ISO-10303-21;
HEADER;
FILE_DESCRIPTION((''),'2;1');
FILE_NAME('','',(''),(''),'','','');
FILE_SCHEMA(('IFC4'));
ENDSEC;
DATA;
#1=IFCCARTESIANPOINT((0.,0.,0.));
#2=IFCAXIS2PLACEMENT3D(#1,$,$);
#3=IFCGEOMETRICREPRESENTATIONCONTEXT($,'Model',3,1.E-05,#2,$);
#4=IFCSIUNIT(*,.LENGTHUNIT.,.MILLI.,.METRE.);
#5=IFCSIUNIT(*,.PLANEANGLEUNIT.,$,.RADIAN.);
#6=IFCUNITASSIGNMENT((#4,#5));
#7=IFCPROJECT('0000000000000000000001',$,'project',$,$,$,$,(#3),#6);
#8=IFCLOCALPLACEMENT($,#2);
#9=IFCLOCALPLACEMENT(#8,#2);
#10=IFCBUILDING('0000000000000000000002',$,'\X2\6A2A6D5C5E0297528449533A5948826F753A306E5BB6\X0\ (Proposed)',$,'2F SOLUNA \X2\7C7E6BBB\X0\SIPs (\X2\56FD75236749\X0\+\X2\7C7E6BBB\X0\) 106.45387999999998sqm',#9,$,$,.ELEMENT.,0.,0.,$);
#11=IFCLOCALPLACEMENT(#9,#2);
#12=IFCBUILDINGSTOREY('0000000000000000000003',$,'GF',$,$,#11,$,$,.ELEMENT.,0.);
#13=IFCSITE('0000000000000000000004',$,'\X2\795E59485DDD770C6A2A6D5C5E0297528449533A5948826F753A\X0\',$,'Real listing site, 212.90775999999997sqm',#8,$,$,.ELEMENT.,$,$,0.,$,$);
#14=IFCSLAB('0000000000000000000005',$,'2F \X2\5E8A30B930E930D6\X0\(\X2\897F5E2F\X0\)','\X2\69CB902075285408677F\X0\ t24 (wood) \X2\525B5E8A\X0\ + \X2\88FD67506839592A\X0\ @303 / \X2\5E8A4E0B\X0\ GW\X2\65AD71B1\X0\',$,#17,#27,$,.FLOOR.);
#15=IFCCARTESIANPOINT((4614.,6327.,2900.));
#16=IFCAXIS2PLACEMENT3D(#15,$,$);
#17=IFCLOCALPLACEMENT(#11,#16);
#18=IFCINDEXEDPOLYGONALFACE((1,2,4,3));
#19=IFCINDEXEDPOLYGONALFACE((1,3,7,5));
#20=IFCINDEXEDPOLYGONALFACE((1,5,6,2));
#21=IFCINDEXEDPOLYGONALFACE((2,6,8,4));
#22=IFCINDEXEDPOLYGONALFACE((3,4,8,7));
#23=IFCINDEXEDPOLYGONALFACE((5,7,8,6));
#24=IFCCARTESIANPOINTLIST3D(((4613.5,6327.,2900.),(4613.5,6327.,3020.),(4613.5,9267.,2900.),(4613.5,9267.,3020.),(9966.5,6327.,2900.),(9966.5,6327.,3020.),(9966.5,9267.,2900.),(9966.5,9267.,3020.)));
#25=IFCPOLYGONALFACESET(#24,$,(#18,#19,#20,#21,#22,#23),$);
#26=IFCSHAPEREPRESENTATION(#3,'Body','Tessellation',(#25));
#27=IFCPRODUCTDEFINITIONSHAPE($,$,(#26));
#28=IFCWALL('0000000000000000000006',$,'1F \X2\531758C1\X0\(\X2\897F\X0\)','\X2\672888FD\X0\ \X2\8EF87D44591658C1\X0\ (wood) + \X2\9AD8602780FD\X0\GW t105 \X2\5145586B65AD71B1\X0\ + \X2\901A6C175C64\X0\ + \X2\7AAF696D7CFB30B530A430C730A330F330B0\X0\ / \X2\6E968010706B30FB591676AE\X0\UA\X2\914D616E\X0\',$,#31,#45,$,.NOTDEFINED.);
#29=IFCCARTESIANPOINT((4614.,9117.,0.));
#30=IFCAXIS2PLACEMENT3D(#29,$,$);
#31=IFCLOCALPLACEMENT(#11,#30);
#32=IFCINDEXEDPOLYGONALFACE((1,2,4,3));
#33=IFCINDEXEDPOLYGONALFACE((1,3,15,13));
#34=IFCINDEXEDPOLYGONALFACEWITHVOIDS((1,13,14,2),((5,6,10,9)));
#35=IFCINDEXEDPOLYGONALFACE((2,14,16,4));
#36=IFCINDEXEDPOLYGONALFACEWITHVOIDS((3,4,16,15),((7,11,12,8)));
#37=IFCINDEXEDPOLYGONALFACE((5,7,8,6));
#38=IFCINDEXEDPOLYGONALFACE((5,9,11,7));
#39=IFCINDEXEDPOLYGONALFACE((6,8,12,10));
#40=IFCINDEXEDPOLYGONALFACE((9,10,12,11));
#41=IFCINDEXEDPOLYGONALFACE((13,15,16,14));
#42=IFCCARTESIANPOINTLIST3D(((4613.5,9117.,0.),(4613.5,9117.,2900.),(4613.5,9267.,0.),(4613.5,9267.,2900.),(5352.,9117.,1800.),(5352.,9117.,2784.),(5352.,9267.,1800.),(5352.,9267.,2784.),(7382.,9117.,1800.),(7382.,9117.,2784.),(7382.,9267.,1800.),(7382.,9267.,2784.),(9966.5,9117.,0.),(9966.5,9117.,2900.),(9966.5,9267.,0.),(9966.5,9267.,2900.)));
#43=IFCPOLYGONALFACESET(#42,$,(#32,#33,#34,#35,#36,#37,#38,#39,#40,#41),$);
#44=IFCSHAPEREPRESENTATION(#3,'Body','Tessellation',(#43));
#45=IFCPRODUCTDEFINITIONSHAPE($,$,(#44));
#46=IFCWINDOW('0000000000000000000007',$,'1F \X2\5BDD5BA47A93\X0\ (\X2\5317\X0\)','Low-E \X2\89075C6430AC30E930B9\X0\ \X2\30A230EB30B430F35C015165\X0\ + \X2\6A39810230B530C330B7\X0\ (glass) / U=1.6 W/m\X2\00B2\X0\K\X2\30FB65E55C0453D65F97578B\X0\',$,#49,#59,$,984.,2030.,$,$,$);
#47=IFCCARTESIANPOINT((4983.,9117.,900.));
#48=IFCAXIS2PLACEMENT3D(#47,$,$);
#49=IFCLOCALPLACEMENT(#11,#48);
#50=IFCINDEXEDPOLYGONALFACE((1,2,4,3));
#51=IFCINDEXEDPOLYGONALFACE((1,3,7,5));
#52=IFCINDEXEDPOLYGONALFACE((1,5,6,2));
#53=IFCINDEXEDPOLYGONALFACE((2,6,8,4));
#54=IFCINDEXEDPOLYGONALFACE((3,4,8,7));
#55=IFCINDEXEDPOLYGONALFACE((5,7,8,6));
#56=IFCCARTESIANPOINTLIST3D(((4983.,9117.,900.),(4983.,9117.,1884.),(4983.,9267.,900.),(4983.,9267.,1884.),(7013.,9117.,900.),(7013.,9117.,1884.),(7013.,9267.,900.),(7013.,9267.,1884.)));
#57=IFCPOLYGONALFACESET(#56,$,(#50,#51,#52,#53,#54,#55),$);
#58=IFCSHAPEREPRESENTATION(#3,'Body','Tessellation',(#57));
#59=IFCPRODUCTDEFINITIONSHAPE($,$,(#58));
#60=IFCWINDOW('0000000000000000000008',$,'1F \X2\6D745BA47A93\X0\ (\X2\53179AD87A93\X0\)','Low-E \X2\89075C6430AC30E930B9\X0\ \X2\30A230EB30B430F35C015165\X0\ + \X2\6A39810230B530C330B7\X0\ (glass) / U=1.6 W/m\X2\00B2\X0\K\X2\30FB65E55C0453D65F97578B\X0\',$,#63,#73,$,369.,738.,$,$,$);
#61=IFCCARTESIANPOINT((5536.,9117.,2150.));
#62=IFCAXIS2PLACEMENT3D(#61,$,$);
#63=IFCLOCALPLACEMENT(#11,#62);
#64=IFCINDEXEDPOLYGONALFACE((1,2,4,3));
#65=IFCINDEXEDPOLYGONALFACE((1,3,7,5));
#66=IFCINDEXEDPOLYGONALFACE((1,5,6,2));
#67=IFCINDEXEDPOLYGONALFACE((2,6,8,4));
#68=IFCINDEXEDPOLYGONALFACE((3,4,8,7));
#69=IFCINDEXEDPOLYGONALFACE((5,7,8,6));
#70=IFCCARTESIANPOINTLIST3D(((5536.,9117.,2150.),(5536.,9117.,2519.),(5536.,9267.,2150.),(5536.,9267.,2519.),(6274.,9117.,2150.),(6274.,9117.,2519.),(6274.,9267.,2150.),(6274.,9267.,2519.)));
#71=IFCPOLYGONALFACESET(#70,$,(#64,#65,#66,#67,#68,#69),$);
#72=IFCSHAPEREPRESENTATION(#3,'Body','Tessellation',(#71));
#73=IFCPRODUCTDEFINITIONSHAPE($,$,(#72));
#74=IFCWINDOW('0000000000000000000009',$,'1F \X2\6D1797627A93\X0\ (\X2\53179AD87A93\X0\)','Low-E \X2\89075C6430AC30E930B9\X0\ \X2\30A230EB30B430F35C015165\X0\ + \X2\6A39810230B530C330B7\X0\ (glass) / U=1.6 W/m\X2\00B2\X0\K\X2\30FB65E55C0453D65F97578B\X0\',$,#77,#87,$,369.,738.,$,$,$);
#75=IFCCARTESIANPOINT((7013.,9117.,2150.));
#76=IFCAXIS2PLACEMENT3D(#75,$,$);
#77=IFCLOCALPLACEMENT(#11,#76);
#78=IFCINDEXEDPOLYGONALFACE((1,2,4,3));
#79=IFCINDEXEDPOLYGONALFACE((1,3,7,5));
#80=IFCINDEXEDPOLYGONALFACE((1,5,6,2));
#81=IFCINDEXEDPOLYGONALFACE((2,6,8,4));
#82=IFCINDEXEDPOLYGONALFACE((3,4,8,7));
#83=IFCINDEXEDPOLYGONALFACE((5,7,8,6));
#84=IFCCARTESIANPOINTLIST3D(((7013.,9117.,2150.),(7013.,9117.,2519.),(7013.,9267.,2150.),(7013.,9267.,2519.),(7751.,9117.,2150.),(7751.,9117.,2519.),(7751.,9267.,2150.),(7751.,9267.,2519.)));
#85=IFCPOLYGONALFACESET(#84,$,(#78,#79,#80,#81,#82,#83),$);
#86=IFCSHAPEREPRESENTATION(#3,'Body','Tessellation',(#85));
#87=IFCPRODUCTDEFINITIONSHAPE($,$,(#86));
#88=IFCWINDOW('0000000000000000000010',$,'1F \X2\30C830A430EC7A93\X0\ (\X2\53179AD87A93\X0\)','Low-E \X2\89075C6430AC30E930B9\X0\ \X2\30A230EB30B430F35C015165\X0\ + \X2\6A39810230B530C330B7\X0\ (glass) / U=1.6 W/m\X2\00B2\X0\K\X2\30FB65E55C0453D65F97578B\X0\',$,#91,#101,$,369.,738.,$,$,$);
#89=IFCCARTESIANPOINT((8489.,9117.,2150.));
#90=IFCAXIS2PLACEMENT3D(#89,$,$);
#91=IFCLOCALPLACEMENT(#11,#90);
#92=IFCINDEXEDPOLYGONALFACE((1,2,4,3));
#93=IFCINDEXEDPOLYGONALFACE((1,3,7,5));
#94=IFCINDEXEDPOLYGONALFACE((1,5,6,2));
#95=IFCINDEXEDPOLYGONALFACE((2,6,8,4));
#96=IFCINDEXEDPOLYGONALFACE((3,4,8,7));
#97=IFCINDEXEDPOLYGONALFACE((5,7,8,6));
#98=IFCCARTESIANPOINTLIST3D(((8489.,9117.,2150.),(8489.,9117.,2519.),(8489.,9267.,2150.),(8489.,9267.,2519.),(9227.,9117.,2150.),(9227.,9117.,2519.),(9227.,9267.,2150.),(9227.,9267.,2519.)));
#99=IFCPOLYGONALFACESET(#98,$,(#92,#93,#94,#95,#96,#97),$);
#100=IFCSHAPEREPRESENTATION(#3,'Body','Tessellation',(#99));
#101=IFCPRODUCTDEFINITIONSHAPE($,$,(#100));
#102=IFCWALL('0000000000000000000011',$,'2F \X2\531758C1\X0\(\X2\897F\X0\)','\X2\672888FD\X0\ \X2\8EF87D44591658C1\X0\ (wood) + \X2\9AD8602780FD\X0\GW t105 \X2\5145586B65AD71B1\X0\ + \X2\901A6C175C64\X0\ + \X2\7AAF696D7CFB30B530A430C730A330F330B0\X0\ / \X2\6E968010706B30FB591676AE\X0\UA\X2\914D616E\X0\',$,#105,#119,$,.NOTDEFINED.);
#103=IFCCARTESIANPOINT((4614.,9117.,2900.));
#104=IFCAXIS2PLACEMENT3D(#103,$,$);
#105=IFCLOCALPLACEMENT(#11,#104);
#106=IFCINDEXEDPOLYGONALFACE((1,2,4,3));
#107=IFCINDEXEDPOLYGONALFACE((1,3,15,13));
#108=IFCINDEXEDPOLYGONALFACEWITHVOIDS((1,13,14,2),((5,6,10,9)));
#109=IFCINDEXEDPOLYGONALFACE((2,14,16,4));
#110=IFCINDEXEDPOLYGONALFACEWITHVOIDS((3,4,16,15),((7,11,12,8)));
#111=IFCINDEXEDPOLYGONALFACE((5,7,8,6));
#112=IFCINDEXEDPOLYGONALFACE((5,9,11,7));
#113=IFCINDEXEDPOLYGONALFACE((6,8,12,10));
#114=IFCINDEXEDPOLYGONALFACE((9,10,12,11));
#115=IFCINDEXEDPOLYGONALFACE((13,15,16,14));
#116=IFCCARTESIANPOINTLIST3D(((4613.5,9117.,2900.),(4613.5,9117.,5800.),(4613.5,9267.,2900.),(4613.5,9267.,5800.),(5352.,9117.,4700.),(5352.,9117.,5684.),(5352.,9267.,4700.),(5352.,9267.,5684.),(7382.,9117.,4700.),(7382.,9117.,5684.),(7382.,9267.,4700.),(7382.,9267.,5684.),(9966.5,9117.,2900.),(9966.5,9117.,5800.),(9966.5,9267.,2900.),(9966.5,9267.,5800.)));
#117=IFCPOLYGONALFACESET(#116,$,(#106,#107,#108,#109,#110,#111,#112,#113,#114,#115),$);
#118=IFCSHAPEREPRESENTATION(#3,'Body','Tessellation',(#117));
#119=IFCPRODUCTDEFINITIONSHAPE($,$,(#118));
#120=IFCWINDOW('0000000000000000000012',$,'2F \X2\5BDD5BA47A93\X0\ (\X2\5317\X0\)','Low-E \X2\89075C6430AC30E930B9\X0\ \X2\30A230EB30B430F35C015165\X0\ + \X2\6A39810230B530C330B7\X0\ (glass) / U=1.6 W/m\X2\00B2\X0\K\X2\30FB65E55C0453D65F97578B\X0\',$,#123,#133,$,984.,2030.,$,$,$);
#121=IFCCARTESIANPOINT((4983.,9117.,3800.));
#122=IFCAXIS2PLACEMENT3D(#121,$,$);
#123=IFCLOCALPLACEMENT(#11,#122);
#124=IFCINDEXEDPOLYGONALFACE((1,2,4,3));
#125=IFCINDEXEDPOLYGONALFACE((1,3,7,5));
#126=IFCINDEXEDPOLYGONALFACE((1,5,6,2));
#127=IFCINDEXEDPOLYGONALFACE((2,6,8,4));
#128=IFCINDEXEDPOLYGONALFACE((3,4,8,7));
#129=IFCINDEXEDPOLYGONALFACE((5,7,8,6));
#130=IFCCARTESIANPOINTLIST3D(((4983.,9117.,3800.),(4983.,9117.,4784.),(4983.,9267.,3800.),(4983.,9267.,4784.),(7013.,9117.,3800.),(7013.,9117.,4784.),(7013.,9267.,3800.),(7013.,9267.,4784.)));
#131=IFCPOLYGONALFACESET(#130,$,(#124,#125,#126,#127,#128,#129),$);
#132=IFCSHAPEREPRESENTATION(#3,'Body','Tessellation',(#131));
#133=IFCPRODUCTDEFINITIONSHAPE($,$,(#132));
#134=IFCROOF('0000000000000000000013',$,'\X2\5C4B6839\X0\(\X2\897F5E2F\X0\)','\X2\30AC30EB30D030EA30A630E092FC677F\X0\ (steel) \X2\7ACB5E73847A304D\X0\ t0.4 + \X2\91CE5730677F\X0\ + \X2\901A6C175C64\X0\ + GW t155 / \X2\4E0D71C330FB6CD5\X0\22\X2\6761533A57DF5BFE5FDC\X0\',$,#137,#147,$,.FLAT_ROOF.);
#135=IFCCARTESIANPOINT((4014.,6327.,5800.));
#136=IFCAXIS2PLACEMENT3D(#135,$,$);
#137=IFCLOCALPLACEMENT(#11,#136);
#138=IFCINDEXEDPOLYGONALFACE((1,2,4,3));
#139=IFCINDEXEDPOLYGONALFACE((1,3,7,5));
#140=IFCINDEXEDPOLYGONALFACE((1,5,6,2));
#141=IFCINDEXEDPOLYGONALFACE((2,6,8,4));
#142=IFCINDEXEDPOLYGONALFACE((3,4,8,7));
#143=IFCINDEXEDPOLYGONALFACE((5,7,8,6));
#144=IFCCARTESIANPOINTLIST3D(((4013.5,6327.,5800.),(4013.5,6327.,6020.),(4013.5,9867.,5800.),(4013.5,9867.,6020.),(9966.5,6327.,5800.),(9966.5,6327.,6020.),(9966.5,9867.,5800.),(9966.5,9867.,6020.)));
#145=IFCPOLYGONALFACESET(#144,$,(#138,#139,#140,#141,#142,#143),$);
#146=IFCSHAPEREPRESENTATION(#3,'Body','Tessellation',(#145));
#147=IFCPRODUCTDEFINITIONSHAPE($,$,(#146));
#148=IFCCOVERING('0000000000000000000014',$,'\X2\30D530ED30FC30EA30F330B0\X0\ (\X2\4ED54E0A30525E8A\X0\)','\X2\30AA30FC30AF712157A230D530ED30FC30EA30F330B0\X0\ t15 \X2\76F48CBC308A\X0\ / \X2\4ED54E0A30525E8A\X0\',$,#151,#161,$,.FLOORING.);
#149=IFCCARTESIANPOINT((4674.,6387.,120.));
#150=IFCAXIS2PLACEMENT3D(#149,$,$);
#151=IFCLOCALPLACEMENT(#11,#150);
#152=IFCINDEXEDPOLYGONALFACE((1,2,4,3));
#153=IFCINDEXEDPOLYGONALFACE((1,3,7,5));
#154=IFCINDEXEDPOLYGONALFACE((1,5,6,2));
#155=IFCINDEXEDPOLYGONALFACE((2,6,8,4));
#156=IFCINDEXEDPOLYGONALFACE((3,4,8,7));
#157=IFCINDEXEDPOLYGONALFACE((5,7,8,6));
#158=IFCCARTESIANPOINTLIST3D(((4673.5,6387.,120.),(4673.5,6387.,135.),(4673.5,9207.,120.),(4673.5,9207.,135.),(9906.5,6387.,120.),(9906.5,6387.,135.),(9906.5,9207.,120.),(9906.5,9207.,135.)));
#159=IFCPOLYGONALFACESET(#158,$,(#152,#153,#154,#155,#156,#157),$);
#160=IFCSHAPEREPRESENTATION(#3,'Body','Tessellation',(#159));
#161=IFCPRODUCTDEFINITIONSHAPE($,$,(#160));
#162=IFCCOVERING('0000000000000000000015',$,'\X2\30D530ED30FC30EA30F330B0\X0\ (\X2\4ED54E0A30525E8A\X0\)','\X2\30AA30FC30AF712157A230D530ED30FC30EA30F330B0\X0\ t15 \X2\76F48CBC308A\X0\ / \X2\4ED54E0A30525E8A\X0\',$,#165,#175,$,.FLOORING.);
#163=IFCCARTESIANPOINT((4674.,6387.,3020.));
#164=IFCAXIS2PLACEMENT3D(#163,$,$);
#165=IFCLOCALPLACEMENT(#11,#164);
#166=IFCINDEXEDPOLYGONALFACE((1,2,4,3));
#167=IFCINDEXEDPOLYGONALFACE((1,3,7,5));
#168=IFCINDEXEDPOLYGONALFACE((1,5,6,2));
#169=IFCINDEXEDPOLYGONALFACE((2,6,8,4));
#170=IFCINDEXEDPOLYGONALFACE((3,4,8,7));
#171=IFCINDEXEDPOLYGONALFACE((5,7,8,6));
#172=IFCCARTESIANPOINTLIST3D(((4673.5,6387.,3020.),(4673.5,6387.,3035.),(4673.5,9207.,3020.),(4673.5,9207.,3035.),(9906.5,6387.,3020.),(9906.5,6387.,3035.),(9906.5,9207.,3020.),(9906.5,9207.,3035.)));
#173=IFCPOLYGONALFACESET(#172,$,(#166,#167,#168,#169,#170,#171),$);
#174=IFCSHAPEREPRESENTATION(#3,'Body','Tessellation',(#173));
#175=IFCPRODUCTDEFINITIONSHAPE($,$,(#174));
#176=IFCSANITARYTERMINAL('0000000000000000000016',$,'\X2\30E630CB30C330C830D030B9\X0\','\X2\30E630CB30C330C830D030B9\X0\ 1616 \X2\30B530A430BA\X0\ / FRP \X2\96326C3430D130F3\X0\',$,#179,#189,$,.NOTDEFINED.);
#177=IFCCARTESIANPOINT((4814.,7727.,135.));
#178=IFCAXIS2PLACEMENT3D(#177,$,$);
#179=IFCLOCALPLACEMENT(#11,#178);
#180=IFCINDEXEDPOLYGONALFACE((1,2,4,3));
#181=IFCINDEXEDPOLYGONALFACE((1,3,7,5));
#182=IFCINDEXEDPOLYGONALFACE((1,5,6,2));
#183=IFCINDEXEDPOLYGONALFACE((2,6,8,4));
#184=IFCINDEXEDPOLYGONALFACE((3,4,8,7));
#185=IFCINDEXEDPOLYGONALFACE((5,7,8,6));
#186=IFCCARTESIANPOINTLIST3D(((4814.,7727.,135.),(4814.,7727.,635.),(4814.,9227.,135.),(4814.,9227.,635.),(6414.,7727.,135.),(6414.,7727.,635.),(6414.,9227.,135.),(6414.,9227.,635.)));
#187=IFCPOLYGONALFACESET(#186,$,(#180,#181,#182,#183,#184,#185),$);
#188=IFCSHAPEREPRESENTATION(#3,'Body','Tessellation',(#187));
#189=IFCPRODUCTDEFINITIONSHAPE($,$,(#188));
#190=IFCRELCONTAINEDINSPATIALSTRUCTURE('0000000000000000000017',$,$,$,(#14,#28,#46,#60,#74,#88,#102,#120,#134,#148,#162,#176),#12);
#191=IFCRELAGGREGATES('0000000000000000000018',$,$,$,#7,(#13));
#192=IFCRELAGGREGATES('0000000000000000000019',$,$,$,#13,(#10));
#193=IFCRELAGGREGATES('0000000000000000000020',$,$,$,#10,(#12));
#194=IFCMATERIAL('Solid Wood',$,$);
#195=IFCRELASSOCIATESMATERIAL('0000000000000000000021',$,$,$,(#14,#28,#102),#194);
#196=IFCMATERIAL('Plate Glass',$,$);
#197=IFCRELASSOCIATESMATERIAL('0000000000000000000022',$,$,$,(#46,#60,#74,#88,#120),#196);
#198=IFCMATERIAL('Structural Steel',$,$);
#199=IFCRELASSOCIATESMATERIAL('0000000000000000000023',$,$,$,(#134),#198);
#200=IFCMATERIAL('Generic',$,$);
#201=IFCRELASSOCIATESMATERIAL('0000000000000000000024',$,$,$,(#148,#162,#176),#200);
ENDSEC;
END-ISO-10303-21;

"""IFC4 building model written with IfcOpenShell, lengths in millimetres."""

from ifc_helpers import new_model, si_unit, frame, frame_2d, origin, place, context, project, spatial, rectangle, extrude, material, element, fill, save


model = new_model("IFC4")

# Units and contexts
model_context = context("Model", 3, precision=1e-05, world=origin())
ifc_project = project(units=[si_unit("LENGTHUNIT", "METRE", prefix="MILLI"), si_unit("PLANEANGLEUNIT", "RADIAN")], contexts=[model_context])

# Site, building, storey
site_placement = place(None, origin())
site = spatial("IfcSite", under=ifc_project, at=site_placement, Name="神奈川県横浜市青葉区奈良町", ObjectType="Real listing site, 212.90775999999997sqm", CompositionType="ELEMENT", RefElevation=0.0)
building_placement = place(site_placement, origin())
building = spatial("IfcBuilding", under=site, at=building_placement, Name="横浜市青葉区奈良町の家 (Proposed)", ObjectType="2F SOLUNA 籾殻SIPs (国産杉+籾殻) 106.45387999999998sqm", CompositionType="ELEMENT", ElevationOfRefHeight=0.0, ElevationOfTerrain=0.0)
storey_placement = place(building_placement, origin())
storey = spatial("IfcBuildingStorey", under=building, at=storey_placement, Name="GF", CompositionType="ELEMENT", Elevation=0.0)

# Slab
ifc_material_1 = material(Name="Solid Wood")
slab_1_placement = place(storey_placement, frame((4614.0, 6327.0, 2900.0)))
element("IfcSlab", 1, at=slab_1_placement, inside=storey, material=ifc_material_1, Name="2F 床スラブ(西帯)", Description="構造用合板 t24 (wood) 剛床 + 製材根太 @303 / 床下 GW断熱", PredefinedType="FLOOR", context=model_context, shape_type="SweptSolid", body=[
    extrude(rectangle(XDim=5353.0, YDim=2940.0, at=frame_2d((2676.0, 1470.0))), frame((4614.0, 6327.0, 2900.0)), (0.0, 0.0, 1.0), 120.0),
])

# Wall, openings, windows
wall_1_placement = place(storey_placement, frame((4614.0, 9117.0, 0.0)))
wall_1 = element("IfcWall", 2, at=wall_1_placement, inside=storey, material=ifc_material_1, Name="1F 北壁(西)", Description="木製 軸組外壁 (wood) + 高性能GW t105 充填断熱 + 通気層 + 窯業系サイディング / 準耐火・外皮UA配慮", PredefinedType="NOTDEFINED", context=model_context, shape_type="SweptSolid", body=[
    extrude(rectangle(XDim=5353.0, YDim=150.0, at=frame_2d((2676.0, 75.0))), frame((4614.0, 9117.0, 0.0)), (0.0, 0.0, 1.0), 2900.0),
])
opening_1_placement = place(storey_placement, frame((4983.0, 9117.0, 900.0)))
opening_1 = element("IfcOpeningElement", 3, at=opening_1_placement, cuts=wall_1, PredefinedType="NOTDEFINED", context=model_context, shape_type="SweptSolid", body=[
    extrude(rectangle(XDim=2030.0, YDim=150.0, at=frame_2d((1015.0, 75.0))), frame((4983.0, 9117.0, 900.0)), (0.0, 0.0, 1.0), 984.0),
])
opening_2_placement = place(storey_placement, frame((5536.0, 9117.0, 2150.0)))
opening_2 = element("IfcOpeningElement", 4, at=opening_2_placement, cuts=wall_1, PredefinedType="NOTDEFINED", context=model_context, shape_type="SweptSolid", body=[
    extrude(rectangle(XDim=738.0, YDim=150.0, at=frame_2d((369.0, 75.0))), frame((5536.0, 9117.0, 2150.0)), (0.0, 0.0, 1.0), 369.0),
])
opening_3_placement = place(storey_placement, frame((7013.0, 9117.0, 2150.0)))
opening_3 = element("IfcOpeningElement", 5, at=opening_3_placement, cuts=wall_1, PredefinedType="NOTDEFINED", context=model_context, shape_type="SweptSolid", body=[
    extrude(rectangle(XDim=738.0, YDim=150.0, at=frame_2d((369.0, 75.0))), frame((7013.0, 9117.0, 2150.0)), (0.0, 0.0, 1.0), 369.0),
])
opening_4_placement = place(storey_placement, frame((8489.0, 9117.0, 2150.0)))
opening_4 = element("IfcOpeningElement", 6, at=opening_4_placement, cuts=wall_1, PredefinedType="NOTDEFINED", context=model_context, shape_type="SweptSolid", body=[
    extrude(rectangle(XDim=738.0, YDim=150.0, at=frame_2d((369.0, 75.0))), frame((8489.0, 9117.0, 2150.0)), (0.0, 0.0, 1.0), 369.0),
])
ifc_material_2 = material(Name="Plate Glass")
window_1_placement = place(storey_placement, frame((4983.0, 9117.0, 900.0)))
window_1 = element("IfcWindow", 7, at=window_1_placement, inside=storey, material=ifc_material_2, Name="1F 寝室窓 (北)", Description="Low-E 複層ガラス アルゴン封入 + 樹脂サッシ (glass) / U=1.6 W/m²K・日射取得型", OverallHeight=984.0, OverallWidth=2030.0, context=model_context, shape_type="SweptSolid", body=[
    extrude(rectangle(XDim=2030.0, YDim=150.0, at=frame_2d((1015.0, 75.0))), frame((4983.0, 9117.0, 900.0)), (0.0, 0.0, 1.0), 984.0),
])
fill(opening_1, window_1)
window_2_placement = place(storey_placement, frame((5536.0, 9117.0, 2150.0)))
window_2 = element("IfcWindow", 8, at=window_2_placement, inside=storey, material=ifc_material_2, Name="1F 浴室窓 (北高窓)", Description="Low-E 複層ガラス アルゴン封入 + 樹脂サッシ (glass) / U=1.6 W/m²K・日射取得型", OverallHeight=369.0, OverallWidth=738.0, context=model_context, shape_type="SweptSolid", body=[
    extrude(rectangle(XDim=738.0, YDim=150.0, at=frame_2d((369.0, 75.0))), frame((5536.0, 9117.0, 2150.0)), (0.0, 0.0, 1.0), 369.0),
])
fill(opening_2, window_2)
window_3_placement = place(storey_placement, frame((7013.0, 9117.0, 2150.0)))
window_3 = element("IfcWindow", 9, at=window_3_placement, inside=storey, material=ifc_material_2, Name="1F 洗面窓 (北高窓)", Description="Low-E 複層ガラス アルゴン封入 + 樹脂サッシ (glass) / U=1.6 W/m²K・日射取得型", OverallHeight=369.0, OverallWidth=738.0, context=model_context, shape_type="SweptSolid", body=[
    extrude(rectangle(XDim=738.0, YDim=150.0, at=frame_2d((369.0, 75.0))), frame((7013.0, 9117.0, 2150.0)), (0.0, 0.0, 1.0), 369.0),
])
fill(opening_3, window_3)
window_4_placement = place(storey_placement, frame((8489.0, 9117.0, 2150.0)))
window_4 = element("IfcWindow", 10, at=window_4_placement, inside=storey, material=ifc_material_2, Name="1F トイレ窓 (北高窓)", Description="Low-E 複層ガラス アルゴン封入 + 樹脂サッシ (glass) / U=1.6 W/m²K・日射取得型", OverallHeight=369.0, OverallWidth=738.0, context=model_context, shape_type="SweptSolid", body=[
    extrude(rectangle(XDim=738.0, YDim=150.0, at=frame_2d((369.0, 75.0))), frame((8489.0, 9117.0, 2150.0)), (0.0, 0.0, 1.0), 369.0),
])
fill(opening_4, window_4)

# Wall, opening, window
wall_2_placement = place(storey_placement, frame((4614.0, 9117.0, 2900.0)))
wall_2 = element("IfcWall", 11, at=wall_2_placement, inside=storey, material=ifc_material_1, Name="2F 北壁(西)", Description="木製 軸組外壁 (wood) + 高性能GW t105 充填断熱 + 通気層 + 窯業系サイディング / 準耐火・外皮UA配慮", PredefinedType="NOTDEFINED", context=model_context, shape_type="SweptSolid", body=[
    extrude(rectangle(XDim=5353.0, YDim=150.0, at=frame_2d((2676.0, 75.0))), frame((4614.0, 9117.0, 2900.0)), (0.0, 0.0, 1.0), 2900.0),
])
opening_5_placement = place(storey_placement, frame((4983.0, 9117.0, 3800.0)))
opening_5 = element("IfcOpeningElement", 12, at=opening_5_placement, cuts=wall_2, PredefinedType="NOTDEFINED", context=model_context, shape_type="SweptSolid", body=[
    extrude(rectangle(XDim=2030.0, YDim=150.0, at=frame_2d((1015.0, 75.0))), frame((4983.0, 9117.0, 3800.0)), (0.0, 0.0, 1.0), 984.0),
])
window_5_placement = place(storey_placement, frame((4983.0, 9117.0, 3800.0)))
window_5 = element("IfcWindow", 13, at=window_5_placement, inside=storey, material=ifc_material_2, Name="2F 寝室窓 (北)", Description="Low-E 複層ガラス アルゴン封入 + 樹脂サッシ (glass) / U=1.6 W/m²K・日射取得型", OverallHeight=984.0, OverallWidth=2030.0, context=model_context, shape_type="SweptSolid", body=[
    extrude(rectangle(XDim=2030.0, YDim=150.0, at=frame_2d((1015.0, 75.0))), frame((4983.0, 9117.0, 3800.0)), (0.0, 0.0, 1.0), 984.0),
])
fill(opening_5, window_5)

# Roof
ifc_material_3 = material(Name="Structural Steel")
for number, where, name in (
    (14, (4014.0, 6327.0, 5800.0), "屋根(西帯)"),
):
    element("IfcRoof", number, at=place(storey_placement, frame(where)), inside=storey, material=ifc_material_3, Name=name, Description="ガルバリウム鋼板 (steel) 立平葺き t0.4 + 野地板 + 通気層 + GW t155 / 不燃・法22条区域対応", PredefinedType="FLAT_ROOF", context=model_context, shape_type="SweptSolid", body=[
        extrude(rectangle(XDim=5953.0, YDim=3540.0, at=frame_2d((2976.0, 1770.0))), frame((4014.0, 6327.0, 5800.0)), (0.0, 0.0, 1.0), 220.0),
    ])

# Coverings
ifc_material_4 = material(Name="Generic")
covering_1_placement = place(storey_placement, frame((4674.0, 6387.0, 120.0)))
element("IfcCovering", 15, at=covering_1_placement, inside=storey, material=ifc_material_4, Name="フローリング (仕上げ床)", Description="オーク無垢フローリング t15 直貼り / 仕上げ床", PredefinedType="FLOORING", context=model_context, shape_type="SweptSolid", body=[
    extrude(rectangle(XDim=5233.0, YDim=2820.0, at=frame_2d((2616.0, 1410.0))), frame((4674.0, 6387.0, 120.0)), (0.0, 0.0, 1.0), 15.0),
])
covering_2_placement = place(storey_placement, frame((4674.0, 6387.0, 3020.0)))
element("IfcCovering", 16, at=covering_2_placement, inside=storey, material=ifc_material_4, Name="フローリング (仕上げ床)", Description="オーク無垢フローリング t15 直貼り / 仕上げ床", PredefinedType="FLOORING", context=model_context, shape_type="SweptSolid", body=[
    extrude(rectangle(XDim=5233.0, YDim=2820.0, at=frame_2d((2616.0, 1410.0))), frame((4674.0, 6387.0, 3020.0)), (0.0, 0.0, 1.0), 15.0),
])

# Sanitary terminal
sanitary_terminal_placement = place(storey_placement, frame((4814.0, 7727.0, 135.0)))
element("IfcSanitaryTerminal", 17, at=sanitary_terminal_placement, inside=storey, material=ifc_material_4, Name="ユニットバス", Description="ユニットバス 1616 サイズ / FRP 防水パン", PredefinedType="NOTDEFINED", context=model_context, shape_type="SweptSolid", body=[
    extrude(rectangle(XDim=1600.0, YDim=1500.0, at=frame_2d((800.0, 750.0))), frame((4814.0, 7727.0, 135.0)), (0.0, 0.0, 1.0), 500.0),
])

save(model, "model.ifc")
